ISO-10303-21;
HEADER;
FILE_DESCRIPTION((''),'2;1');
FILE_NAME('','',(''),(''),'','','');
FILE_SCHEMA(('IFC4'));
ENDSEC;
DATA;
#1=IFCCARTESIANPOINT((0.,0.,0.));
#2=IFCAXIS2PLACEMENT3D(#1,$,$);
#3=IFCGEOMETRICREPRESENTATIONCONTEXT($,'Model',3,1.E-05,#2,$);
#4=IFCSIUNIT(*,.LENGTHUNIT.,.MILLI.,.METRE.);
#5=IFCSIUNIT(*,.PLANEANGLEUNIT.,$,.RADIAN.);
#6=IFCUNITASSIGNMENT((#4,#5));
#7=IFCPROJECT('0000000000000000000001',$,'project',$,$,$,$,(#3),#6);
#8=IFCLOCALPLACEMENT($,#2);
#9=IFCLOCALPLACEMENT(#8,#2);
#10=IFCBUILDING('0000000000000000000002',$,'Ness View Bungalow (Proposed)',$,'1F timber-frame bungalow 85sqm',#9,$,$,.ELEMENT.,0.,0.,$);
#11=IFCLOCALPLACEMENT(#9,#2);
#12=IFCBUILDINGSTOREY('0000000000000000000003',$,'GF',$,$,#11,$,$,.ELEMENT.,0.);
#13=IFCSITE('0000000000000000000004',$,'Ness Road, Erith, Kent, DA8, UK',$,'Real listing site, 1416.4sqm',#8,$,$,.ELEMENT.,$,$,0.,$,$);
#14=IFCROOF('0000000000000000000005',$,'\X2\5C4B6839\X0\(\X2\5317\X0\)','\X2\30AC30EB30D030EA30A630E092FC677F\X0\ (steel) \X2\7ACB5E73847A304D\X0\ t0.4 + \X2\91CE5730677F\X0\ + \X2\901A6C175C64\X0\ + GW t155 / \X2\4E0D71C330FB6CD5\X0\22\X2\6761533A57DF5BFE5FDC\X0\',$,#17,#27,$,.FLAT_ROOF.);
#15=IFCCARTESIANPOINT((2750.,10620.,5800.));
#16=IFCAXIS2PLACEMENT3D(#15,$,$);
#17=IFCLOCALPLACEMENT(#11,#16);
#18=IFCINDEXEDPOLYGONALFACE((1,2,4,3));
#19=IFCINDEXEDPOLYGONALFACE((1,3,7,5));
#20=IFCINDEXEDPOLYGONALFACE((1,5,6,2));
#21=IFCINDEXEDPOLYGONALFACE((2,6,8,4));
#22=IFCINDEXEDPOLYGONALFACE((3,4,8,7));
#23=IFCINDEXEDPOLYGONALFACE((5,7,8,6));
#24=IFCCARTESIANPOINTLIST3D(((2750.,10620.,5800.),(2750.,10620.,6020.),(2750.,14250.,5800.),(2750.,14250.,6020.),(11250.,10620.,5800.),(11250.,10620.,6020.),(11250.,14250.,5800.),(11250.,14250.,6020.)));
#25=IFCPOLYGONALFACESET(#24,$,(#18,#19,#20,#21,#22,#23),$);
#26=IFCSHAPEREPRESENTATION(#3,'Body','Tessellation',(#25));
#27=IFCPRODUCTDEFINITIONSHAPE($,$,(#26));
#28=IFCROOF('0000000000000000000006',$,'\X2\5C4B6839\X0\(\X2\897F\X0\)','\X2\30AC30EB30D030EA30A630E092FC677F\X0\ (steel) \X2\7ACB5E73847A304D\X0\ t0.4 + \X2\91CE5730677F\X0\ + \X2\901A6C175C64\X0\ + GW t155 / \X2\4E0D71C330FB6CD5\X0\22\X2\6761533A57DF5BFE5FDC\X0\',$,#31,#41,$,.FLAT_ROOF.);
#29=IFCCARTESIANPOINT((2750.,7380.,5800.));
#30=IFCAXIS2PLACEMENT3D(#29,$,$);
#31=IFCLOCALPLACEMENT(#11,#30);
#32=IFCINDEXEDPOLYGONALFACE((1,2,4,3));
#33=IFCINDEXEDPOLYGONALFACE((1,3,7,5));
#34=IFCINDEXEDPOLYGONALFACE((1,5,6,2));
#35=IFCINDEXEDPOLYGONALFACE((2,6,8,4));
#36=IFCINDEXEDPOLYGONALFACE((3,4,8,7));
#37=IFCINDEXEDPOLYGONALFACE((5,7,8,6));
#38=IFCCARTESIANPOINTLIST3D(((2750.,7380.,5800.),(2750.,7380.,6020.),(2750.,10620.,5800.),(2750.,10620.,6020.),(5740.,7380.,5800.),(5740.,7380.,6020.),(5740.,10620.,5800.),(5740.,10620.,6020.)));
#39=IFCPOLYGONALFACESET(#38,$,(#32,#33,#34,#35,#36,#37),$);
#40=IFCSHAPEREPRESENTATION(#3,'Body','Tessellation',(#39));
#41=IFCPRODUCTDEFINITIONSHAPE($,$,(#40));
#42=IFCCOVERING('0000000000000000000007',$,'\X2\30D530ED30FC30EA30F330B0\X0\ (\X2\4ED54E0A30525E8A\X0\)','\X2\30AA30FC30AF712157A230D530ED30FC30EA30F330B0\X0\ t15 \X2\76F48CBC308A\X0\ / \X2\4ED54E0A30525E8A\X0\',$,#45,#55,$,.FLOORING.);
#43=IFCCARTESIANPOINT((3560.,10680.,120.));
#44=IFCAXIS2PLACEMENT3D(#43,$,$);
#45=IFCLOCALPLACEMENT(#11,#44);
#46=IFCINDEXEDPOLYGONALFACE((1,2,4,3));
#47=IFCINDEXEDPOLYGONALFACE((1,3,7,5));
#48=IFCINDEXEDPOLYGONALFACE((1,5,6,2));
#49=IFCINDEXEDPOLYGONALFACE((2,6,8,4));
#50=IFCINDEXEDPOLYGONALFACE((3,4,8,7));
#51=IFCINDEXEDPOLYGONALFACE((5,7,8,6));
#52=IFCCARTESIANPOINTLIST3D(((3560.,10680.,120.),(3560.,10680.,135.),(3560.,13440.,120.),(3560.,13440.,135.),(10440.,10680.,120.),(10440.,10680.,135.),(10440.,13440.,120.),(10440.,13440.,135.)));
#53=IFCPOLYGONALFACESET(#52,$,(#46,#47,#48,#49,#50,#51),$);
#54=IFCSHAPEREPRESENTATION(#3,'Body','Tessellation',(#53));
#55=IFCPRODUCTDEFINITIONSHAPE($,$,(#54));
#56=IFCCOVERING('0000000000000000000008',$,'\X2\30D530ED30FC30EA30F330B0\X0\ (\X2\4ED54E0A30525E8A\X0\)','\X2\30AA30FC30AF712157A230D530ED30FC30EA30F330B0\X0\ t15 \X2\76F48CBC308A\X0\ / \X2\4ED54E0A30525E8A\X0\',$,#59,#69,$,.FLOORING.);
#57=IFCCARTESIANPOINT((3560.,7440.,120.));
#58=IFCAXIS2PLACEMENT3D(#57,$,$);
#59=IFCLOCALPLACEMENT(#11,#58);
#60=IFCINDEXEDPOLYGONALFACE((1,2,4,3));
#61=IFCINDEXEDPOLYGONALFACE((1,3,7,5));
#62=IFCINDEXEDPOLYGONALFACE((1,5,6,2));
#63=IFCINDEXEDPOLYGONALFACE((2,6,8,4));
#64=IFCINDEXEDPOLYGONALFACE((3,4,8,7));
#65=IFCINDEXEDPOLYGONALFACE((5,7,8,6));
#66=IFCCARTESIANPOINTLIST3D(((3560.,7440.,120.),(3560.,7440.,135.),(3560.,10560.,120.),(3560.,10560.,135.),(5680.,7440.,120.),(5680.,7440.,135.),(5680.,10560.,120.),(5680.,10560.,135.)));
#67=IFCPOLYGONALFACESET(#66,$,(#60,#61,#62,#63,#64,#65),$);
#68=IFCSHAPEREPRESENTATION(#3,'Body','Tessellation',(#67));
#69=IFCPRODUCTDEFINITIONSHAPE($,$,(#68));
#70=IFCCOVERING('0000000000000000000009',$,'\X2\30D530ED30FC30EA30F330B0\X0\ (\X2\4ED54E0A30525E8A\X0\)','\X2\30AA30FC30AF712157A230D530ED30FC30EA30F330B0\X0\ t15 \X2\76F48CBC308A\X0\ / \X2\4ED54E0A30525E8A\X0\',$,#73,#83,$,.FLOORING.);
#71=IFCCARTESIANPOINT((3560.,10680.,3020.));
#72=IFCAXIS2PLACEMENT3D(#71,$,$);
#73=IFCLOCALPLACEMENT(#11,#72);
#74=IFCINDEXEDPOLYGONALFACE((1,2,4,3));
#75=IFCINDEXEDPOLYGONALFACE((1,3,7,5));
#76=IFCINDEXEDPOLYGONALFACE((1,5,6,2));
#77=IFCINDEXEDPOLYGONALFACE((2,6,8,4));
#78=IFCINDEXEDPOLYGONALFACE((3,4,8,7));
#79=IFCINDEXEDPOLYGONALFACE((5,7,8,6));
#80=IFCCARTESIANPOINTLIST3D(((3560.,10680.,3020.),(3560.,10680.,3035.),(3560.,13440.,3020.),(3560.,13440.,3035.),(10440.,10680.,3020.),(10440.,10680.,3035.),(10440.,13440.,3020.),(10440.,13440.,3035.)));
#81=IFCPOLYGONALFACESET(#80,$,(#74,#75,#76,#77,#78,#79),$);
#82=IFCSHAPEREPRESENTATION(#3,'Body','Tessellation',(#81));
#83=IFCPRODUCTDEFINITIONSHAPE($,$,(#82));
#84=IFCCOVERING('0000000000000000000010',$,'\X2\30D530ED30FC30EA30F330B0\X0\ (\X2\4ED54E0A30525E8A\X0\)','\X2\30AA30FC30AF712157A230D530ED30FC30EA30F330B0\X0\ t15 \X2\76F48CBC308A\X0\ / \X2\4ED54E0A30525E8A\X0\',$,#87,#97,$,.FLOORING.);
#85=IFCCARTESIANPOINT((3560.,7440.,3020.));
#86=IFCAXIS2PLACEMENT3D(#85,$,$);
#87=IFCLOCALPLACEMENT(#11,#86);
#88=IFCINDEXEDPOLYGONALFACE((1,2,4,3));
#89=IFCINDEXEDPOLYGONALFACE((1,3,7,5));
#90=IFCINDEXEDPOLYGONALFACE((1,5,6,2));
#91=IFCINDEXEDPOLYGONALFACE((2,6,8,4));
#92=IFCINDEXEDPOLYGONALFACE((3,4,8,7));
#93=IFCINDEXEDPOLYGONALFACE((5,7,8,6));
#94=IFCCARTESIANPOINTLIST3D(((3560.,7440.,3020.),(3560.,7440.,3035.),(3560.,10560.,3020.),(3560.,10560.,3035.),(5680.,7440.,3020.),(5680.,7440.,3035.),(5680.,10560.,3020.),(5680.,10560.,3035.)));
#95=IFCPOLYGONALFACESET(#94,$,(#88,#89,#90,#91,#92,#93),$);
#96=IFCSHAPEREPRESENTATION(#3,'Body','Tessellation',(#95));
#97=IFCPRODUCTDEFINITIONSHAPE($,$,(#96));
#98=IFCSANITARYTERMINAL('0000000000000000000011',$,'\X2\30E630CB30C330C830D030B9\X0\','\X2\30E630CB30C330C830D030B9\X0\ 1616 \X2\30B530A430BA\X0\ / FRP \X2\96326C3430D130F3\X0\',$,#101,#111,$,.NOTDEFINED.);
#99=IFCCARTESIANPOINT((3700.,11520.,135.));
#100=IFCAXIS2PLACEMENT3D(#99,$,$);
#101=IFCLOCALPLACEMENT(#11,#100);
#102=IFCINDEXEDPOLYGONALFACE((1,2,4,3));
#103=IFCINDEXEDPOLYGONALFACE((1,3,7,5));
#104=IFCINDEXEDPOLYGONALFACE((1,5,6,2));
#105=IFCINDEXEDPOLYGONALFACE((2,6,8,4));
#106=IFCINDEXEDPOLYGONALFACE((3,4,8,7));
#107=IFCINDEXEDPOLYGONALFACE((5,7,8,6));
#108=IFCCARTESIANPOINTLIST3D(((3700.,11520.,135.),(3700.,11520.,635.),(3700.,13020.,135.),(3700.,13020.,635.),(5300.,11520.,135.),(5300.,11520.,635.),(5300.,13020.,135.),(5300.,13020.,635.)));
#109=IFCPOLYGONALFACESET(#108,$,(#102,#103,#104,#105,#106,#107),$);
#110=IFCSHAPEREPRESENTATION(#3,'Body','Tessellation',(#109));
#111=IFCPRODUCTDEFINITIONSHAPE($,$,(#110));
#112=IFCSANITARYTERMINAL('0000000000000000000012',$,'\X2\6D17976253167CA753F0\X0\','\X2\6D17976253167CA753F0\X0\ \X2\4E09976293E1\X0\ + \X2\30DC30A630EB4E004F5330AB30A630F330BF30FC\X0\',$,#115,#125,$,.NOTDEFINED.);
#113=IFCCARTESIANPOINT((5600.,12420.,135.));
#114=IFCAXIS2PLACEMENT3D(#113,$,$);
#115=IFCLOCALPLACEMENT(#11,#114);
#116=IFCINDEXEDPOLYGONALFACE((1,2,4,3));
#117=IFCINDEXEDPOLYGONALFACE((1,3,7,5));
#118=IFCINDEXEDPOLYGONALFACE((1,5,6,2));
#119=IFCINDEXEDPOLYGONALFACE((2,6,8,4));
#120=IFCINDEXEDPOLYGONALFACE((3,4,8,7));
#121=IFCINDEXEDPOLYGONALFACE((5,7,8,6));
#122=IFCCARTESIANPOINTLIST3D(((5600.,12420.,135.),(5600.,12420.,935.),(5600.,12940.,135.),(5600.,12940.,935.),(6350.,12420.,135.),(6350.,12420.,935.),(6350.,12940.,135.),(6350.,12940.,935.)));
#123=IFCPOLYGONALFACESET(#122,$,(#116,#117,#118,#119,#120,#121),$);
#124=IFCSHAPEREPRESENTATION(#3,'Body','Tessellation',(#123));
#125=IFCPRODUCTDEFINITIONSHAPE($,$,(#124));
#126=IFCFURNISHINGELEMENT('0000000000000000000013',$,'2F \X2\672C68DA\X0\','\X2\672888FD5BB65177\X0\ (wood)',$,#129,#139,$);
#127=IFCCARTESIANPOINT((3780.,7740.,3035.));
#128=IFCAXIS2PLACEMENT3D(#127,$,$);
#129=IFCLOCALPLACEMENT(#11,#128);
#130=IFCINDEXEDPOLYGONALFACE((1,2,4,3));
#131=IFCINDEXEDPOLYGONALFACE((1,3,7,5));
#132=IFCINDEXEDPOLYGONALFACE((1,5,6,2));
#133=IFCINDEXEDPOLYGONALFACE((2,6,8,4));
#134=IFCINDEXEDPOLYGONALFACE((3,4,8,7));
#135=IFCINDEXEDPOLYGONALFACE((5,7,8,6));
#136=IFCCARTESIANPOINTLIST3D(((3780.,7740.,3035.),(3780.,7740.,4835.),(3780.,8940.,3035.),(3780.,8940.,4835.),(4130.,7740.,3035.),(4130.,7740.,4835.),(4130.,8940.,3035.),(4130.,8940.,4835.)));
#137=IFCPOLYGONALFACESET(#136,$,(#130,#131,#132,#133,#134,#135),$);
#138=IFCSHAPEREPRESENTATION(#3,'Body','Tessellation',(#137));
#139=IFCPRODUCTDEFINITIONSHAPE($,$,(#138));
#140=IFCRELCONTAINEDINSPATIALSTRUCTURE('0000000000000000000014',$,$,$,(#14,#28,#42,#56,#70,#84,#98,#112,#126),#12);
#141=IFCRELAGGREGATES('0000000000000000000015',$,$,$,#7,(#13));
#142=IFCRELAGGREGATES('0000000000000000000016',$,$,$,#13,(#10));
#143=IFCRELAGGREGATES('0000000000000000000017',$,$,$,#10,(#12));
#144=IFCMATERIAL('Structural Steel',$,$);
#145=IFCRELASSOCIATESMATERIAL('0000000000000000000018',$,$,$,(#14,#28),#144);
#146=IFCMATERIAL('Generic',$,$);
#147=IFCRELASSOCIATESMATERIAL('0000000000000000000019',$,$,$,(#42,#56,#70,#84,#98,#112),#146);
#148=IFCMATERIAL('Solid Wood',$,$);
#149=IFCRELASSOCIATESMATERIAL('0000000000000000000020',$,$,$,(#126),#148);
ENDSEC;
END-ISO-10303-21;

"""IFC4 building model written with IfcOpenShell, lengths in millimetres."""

from ifc_helpers import new_model, si_unit, frame, frame_2d, origin, place, context, project, spatial, rectangle, extrude, material, element, save


model = new_model("IFC4")

# Units and contexts
model_context = context("Model", 3, precision=1e-05, world=origin())
ifc_project = project(units=[si_unit("LENGTHUNIT", "METRE", prefix="MILLI"), si_unit("PLANEANGLEUNIT", "RADIAN")], contexts=[model_context])

# Site, building, storey
site_placement = place(None, origin())
site = spatial("IfcSite", under=ifc_project, at=site_placement, Name="Ness Road, Erith, Kent, DA8, UK", ObjectType="Real listing site, 1416.4sqm", CompositionType="ELEMENT", RefElevation=0.0)
building_placement = place(site_placement, origin())
building = spatial("IfcBuilding", under=site, at=building_placement, Name="Ness View Bungalow (Proposed)", ObjectType="1F timber-frame bungalow 85sqm", CompositionType="ELEMENT", ElevationOfRefHeight=0.0, ElevationOfTerrain=0.0)
storey_placement = place(building_placement, origin())
storey = spatial("IfcBuildingStorey", under=building, at=storey_placement, Name="GF", CompositionType="ELEMENT", Elevation=0.0)

# Shared definitions
ifc_material_1 = material(Name="Solid Wood")

# Roofs
ifc_material_2 = material(Name="Structural Steel")
for number, where, name in (
    (1, (2750.0, 10620.0, 5800.0), "屋根(北)"),
):
    element("IfcRoof", number, at=place(storey_placement, frame(where)), inside=storey, material=ifc_material_2, Name=name, Description="ガルバリウム鋼板 (steel) 立平葺き t0.4 + 野地板 + 通気層 + GW t155 / 不燃・法22条区域対応", PredefinedType="FLAT_ROOF", context=model_context, shape_type="SweptSolid", body=[
        extrude(rectangle(XDim=8500.0, YDim=3630.0, at=frame_2d((4250.0, 1815.0))), frame((2750.0, 10620.0, 5800.0)), (0.0, 0.0, 1.0), 220.0),
    ])
roof_placement = place(storey_placement, frame((2750.0, 7380.0, 5800.0)))
element("IfcRoof", 2, at=roof_placement, inside=storey, material=ifc_material_2, Name="屋根(西)", Description="ガルバリウム鋼板 (steel) 立平葺き t0.4 + 野地板 + 通気層 + GW t155 / 不燃・法22条区域対応", PredefinedType="FLAT_ROOF", context=model_context, shape_type="SweptSolid", body=[
    extrude(rectangle(XDim=2990.0, YDim=3240.0, at=frame_2d((1495.0, 1620.0))), frame((2750.0, 7380.0, 5800.0)), (0.0, 0.0, 1.0), 220.0),
])

# Coverings
ifc_material_3 = material(Name="Generic")
covering_1_placement = place(storey_placement, frame((3560.0, 10680.0, 120.0)))
element("IfcCovering", 3, at=covering_1_placement, inside=storey, material=ifc_material_3, Name="フローリング (仕上げ床)", Description="オーク無垢フローリング t15 直貼り / 仕上げ床", PredefinedType="FLOORING", context=model_context, shape_type="SweptSolid", body=[
    extrude(rectangle(XDim=6880.0, YDim=2760.0, at=frame_2d((3440.0, 1380.0))), frame((3560.0, 10680.0, 120.0)), (0.0, 0.0, 1.0), 15.0),
])
covering_2_placement = place(storey_placement, frame((3560.0, 7440.0, 120.0)))
element("IfcCovering", 4, at=covering_2_placement, inside=storey, material=ifc_material_3, Name="フローリング (仕上げ床)", Description="オーク無垢フローリング t15 直貼り / 仕上げ床", PredefinedType="FLOORING", context=model_context, shape_type="SweptSolid", body=[
    extrude(rectangle(XDim=2120.0, YDim=3120.0, at=frame_2d((1060.0, 1560.0))), frame((3560.0, 7440.0, 120.0)), (0.0, 0.0, 1.0), 15.0),
])
covering_3_placement = place(storey_placement, frame((3560.0, 10680.0, 3020.0)))
element("IfcCovering", 5, at=covering_3_placement, inside=storey, material=ifc_material_3, Name="フローリング (仕上げ床)", Description="オーク無垢フローリング t15 直貼り / 仕上げ床", PredefinedType="FLOORING", context=model_context, shape_type="SweptSolid", body=[
    extrude(rectangle(XDim=6880.0, YDim=2760.0, at=frame_2d((3440.0, 1380.0))), frame((3560.0, 10680.0, 3020.0)), (0.0, 0.0, 1.0), 15.0),
])
covering_4_placement = place(storey_placement, frame((3560.0, 7440.0, 3020.0)))
element("IfcCovering", 6, at=covering_4_placement, inside=storey, material=ifc_material_3, Name="フローリング (仕上げ床)", Description="オーク無垢フローリング t15 直貼り / 仕上げ床", PredefinedType="FLOORING", context=model_context, shape_type="SweptSolid", body=[
    extrude(rectangle(XDim=2120.0, YDim=3120.0, at=frame_2d((1060.0, 1560.0))), frame((3560.0, 7440.0, 3020.0)), (0.0, 0.0, 1.0), 15.0),
])

# Sanitary terminals
sanitary_terminal_1_placement = place(storey_placement, frame((3700.0, 11520.0, 135.0)))
element("IfcSanitaryTerminal", 7, at=sanitary_terminal_1_placement, inside=storey, material=ifc_material_3, Name="ユニットバス", Description="ユニットバス 1616 サイズ / FRP 防水パン", PredefinedType="NOTDEFINED", context=model_context, shape_type="SweptSolid", body=[
    extrude(rectangle(XDim=1600.0, YDim=1500.0, at=frame_2d((800.0, 750.0))), frame((3700.0, 11520.0, 135.0)), (0.0, 0.0, 1.0), 500.0),
])
sanitary_terminal_2_placement = place(storey_placement, frame((5600.0, 12420.0, 135.0)))
element("IfcSanitaryTerminal", 8, at=sanitary_terminal_2_placement, inside=storey, material=ifc_material_3, Name="洗面化粧台", Description="洗面化粧台 三面鏡 + ボウル一体カウンター", PredefinedType="NOTDEFINED", context=model_context, shape_type="SweptSolid", body=[
    extrude(rectangle(XDim=750.0, YDim=520.0, at=frame_2d((375.0, 260.0))), frame((5600.0, 12420.0, 135.0)), (0.0, 0.0, 1.0), 800.0),
])

# Furnishing element
furnishing_placement = place(storey_placement, frame((3780.0, 7740.0, 3035.0)))
element("IfcFurnishingElement", 9, at=furnishing_placement, inside=storey, material=ifc_material_1, Name="2F 本棚", Description="木製家具 (wood)", context=model_context, shape_type="SweptSolid", body=[
    extrude(rectangle(XDim=350.0, YDim=1200.0, at=frame_2d((175.0, 600.0))), frame((3780.0, 7740.0, 3035.0)), (0.0, 0.0, 1.0), 1800.0),
])

save(model, "model.ifc")
